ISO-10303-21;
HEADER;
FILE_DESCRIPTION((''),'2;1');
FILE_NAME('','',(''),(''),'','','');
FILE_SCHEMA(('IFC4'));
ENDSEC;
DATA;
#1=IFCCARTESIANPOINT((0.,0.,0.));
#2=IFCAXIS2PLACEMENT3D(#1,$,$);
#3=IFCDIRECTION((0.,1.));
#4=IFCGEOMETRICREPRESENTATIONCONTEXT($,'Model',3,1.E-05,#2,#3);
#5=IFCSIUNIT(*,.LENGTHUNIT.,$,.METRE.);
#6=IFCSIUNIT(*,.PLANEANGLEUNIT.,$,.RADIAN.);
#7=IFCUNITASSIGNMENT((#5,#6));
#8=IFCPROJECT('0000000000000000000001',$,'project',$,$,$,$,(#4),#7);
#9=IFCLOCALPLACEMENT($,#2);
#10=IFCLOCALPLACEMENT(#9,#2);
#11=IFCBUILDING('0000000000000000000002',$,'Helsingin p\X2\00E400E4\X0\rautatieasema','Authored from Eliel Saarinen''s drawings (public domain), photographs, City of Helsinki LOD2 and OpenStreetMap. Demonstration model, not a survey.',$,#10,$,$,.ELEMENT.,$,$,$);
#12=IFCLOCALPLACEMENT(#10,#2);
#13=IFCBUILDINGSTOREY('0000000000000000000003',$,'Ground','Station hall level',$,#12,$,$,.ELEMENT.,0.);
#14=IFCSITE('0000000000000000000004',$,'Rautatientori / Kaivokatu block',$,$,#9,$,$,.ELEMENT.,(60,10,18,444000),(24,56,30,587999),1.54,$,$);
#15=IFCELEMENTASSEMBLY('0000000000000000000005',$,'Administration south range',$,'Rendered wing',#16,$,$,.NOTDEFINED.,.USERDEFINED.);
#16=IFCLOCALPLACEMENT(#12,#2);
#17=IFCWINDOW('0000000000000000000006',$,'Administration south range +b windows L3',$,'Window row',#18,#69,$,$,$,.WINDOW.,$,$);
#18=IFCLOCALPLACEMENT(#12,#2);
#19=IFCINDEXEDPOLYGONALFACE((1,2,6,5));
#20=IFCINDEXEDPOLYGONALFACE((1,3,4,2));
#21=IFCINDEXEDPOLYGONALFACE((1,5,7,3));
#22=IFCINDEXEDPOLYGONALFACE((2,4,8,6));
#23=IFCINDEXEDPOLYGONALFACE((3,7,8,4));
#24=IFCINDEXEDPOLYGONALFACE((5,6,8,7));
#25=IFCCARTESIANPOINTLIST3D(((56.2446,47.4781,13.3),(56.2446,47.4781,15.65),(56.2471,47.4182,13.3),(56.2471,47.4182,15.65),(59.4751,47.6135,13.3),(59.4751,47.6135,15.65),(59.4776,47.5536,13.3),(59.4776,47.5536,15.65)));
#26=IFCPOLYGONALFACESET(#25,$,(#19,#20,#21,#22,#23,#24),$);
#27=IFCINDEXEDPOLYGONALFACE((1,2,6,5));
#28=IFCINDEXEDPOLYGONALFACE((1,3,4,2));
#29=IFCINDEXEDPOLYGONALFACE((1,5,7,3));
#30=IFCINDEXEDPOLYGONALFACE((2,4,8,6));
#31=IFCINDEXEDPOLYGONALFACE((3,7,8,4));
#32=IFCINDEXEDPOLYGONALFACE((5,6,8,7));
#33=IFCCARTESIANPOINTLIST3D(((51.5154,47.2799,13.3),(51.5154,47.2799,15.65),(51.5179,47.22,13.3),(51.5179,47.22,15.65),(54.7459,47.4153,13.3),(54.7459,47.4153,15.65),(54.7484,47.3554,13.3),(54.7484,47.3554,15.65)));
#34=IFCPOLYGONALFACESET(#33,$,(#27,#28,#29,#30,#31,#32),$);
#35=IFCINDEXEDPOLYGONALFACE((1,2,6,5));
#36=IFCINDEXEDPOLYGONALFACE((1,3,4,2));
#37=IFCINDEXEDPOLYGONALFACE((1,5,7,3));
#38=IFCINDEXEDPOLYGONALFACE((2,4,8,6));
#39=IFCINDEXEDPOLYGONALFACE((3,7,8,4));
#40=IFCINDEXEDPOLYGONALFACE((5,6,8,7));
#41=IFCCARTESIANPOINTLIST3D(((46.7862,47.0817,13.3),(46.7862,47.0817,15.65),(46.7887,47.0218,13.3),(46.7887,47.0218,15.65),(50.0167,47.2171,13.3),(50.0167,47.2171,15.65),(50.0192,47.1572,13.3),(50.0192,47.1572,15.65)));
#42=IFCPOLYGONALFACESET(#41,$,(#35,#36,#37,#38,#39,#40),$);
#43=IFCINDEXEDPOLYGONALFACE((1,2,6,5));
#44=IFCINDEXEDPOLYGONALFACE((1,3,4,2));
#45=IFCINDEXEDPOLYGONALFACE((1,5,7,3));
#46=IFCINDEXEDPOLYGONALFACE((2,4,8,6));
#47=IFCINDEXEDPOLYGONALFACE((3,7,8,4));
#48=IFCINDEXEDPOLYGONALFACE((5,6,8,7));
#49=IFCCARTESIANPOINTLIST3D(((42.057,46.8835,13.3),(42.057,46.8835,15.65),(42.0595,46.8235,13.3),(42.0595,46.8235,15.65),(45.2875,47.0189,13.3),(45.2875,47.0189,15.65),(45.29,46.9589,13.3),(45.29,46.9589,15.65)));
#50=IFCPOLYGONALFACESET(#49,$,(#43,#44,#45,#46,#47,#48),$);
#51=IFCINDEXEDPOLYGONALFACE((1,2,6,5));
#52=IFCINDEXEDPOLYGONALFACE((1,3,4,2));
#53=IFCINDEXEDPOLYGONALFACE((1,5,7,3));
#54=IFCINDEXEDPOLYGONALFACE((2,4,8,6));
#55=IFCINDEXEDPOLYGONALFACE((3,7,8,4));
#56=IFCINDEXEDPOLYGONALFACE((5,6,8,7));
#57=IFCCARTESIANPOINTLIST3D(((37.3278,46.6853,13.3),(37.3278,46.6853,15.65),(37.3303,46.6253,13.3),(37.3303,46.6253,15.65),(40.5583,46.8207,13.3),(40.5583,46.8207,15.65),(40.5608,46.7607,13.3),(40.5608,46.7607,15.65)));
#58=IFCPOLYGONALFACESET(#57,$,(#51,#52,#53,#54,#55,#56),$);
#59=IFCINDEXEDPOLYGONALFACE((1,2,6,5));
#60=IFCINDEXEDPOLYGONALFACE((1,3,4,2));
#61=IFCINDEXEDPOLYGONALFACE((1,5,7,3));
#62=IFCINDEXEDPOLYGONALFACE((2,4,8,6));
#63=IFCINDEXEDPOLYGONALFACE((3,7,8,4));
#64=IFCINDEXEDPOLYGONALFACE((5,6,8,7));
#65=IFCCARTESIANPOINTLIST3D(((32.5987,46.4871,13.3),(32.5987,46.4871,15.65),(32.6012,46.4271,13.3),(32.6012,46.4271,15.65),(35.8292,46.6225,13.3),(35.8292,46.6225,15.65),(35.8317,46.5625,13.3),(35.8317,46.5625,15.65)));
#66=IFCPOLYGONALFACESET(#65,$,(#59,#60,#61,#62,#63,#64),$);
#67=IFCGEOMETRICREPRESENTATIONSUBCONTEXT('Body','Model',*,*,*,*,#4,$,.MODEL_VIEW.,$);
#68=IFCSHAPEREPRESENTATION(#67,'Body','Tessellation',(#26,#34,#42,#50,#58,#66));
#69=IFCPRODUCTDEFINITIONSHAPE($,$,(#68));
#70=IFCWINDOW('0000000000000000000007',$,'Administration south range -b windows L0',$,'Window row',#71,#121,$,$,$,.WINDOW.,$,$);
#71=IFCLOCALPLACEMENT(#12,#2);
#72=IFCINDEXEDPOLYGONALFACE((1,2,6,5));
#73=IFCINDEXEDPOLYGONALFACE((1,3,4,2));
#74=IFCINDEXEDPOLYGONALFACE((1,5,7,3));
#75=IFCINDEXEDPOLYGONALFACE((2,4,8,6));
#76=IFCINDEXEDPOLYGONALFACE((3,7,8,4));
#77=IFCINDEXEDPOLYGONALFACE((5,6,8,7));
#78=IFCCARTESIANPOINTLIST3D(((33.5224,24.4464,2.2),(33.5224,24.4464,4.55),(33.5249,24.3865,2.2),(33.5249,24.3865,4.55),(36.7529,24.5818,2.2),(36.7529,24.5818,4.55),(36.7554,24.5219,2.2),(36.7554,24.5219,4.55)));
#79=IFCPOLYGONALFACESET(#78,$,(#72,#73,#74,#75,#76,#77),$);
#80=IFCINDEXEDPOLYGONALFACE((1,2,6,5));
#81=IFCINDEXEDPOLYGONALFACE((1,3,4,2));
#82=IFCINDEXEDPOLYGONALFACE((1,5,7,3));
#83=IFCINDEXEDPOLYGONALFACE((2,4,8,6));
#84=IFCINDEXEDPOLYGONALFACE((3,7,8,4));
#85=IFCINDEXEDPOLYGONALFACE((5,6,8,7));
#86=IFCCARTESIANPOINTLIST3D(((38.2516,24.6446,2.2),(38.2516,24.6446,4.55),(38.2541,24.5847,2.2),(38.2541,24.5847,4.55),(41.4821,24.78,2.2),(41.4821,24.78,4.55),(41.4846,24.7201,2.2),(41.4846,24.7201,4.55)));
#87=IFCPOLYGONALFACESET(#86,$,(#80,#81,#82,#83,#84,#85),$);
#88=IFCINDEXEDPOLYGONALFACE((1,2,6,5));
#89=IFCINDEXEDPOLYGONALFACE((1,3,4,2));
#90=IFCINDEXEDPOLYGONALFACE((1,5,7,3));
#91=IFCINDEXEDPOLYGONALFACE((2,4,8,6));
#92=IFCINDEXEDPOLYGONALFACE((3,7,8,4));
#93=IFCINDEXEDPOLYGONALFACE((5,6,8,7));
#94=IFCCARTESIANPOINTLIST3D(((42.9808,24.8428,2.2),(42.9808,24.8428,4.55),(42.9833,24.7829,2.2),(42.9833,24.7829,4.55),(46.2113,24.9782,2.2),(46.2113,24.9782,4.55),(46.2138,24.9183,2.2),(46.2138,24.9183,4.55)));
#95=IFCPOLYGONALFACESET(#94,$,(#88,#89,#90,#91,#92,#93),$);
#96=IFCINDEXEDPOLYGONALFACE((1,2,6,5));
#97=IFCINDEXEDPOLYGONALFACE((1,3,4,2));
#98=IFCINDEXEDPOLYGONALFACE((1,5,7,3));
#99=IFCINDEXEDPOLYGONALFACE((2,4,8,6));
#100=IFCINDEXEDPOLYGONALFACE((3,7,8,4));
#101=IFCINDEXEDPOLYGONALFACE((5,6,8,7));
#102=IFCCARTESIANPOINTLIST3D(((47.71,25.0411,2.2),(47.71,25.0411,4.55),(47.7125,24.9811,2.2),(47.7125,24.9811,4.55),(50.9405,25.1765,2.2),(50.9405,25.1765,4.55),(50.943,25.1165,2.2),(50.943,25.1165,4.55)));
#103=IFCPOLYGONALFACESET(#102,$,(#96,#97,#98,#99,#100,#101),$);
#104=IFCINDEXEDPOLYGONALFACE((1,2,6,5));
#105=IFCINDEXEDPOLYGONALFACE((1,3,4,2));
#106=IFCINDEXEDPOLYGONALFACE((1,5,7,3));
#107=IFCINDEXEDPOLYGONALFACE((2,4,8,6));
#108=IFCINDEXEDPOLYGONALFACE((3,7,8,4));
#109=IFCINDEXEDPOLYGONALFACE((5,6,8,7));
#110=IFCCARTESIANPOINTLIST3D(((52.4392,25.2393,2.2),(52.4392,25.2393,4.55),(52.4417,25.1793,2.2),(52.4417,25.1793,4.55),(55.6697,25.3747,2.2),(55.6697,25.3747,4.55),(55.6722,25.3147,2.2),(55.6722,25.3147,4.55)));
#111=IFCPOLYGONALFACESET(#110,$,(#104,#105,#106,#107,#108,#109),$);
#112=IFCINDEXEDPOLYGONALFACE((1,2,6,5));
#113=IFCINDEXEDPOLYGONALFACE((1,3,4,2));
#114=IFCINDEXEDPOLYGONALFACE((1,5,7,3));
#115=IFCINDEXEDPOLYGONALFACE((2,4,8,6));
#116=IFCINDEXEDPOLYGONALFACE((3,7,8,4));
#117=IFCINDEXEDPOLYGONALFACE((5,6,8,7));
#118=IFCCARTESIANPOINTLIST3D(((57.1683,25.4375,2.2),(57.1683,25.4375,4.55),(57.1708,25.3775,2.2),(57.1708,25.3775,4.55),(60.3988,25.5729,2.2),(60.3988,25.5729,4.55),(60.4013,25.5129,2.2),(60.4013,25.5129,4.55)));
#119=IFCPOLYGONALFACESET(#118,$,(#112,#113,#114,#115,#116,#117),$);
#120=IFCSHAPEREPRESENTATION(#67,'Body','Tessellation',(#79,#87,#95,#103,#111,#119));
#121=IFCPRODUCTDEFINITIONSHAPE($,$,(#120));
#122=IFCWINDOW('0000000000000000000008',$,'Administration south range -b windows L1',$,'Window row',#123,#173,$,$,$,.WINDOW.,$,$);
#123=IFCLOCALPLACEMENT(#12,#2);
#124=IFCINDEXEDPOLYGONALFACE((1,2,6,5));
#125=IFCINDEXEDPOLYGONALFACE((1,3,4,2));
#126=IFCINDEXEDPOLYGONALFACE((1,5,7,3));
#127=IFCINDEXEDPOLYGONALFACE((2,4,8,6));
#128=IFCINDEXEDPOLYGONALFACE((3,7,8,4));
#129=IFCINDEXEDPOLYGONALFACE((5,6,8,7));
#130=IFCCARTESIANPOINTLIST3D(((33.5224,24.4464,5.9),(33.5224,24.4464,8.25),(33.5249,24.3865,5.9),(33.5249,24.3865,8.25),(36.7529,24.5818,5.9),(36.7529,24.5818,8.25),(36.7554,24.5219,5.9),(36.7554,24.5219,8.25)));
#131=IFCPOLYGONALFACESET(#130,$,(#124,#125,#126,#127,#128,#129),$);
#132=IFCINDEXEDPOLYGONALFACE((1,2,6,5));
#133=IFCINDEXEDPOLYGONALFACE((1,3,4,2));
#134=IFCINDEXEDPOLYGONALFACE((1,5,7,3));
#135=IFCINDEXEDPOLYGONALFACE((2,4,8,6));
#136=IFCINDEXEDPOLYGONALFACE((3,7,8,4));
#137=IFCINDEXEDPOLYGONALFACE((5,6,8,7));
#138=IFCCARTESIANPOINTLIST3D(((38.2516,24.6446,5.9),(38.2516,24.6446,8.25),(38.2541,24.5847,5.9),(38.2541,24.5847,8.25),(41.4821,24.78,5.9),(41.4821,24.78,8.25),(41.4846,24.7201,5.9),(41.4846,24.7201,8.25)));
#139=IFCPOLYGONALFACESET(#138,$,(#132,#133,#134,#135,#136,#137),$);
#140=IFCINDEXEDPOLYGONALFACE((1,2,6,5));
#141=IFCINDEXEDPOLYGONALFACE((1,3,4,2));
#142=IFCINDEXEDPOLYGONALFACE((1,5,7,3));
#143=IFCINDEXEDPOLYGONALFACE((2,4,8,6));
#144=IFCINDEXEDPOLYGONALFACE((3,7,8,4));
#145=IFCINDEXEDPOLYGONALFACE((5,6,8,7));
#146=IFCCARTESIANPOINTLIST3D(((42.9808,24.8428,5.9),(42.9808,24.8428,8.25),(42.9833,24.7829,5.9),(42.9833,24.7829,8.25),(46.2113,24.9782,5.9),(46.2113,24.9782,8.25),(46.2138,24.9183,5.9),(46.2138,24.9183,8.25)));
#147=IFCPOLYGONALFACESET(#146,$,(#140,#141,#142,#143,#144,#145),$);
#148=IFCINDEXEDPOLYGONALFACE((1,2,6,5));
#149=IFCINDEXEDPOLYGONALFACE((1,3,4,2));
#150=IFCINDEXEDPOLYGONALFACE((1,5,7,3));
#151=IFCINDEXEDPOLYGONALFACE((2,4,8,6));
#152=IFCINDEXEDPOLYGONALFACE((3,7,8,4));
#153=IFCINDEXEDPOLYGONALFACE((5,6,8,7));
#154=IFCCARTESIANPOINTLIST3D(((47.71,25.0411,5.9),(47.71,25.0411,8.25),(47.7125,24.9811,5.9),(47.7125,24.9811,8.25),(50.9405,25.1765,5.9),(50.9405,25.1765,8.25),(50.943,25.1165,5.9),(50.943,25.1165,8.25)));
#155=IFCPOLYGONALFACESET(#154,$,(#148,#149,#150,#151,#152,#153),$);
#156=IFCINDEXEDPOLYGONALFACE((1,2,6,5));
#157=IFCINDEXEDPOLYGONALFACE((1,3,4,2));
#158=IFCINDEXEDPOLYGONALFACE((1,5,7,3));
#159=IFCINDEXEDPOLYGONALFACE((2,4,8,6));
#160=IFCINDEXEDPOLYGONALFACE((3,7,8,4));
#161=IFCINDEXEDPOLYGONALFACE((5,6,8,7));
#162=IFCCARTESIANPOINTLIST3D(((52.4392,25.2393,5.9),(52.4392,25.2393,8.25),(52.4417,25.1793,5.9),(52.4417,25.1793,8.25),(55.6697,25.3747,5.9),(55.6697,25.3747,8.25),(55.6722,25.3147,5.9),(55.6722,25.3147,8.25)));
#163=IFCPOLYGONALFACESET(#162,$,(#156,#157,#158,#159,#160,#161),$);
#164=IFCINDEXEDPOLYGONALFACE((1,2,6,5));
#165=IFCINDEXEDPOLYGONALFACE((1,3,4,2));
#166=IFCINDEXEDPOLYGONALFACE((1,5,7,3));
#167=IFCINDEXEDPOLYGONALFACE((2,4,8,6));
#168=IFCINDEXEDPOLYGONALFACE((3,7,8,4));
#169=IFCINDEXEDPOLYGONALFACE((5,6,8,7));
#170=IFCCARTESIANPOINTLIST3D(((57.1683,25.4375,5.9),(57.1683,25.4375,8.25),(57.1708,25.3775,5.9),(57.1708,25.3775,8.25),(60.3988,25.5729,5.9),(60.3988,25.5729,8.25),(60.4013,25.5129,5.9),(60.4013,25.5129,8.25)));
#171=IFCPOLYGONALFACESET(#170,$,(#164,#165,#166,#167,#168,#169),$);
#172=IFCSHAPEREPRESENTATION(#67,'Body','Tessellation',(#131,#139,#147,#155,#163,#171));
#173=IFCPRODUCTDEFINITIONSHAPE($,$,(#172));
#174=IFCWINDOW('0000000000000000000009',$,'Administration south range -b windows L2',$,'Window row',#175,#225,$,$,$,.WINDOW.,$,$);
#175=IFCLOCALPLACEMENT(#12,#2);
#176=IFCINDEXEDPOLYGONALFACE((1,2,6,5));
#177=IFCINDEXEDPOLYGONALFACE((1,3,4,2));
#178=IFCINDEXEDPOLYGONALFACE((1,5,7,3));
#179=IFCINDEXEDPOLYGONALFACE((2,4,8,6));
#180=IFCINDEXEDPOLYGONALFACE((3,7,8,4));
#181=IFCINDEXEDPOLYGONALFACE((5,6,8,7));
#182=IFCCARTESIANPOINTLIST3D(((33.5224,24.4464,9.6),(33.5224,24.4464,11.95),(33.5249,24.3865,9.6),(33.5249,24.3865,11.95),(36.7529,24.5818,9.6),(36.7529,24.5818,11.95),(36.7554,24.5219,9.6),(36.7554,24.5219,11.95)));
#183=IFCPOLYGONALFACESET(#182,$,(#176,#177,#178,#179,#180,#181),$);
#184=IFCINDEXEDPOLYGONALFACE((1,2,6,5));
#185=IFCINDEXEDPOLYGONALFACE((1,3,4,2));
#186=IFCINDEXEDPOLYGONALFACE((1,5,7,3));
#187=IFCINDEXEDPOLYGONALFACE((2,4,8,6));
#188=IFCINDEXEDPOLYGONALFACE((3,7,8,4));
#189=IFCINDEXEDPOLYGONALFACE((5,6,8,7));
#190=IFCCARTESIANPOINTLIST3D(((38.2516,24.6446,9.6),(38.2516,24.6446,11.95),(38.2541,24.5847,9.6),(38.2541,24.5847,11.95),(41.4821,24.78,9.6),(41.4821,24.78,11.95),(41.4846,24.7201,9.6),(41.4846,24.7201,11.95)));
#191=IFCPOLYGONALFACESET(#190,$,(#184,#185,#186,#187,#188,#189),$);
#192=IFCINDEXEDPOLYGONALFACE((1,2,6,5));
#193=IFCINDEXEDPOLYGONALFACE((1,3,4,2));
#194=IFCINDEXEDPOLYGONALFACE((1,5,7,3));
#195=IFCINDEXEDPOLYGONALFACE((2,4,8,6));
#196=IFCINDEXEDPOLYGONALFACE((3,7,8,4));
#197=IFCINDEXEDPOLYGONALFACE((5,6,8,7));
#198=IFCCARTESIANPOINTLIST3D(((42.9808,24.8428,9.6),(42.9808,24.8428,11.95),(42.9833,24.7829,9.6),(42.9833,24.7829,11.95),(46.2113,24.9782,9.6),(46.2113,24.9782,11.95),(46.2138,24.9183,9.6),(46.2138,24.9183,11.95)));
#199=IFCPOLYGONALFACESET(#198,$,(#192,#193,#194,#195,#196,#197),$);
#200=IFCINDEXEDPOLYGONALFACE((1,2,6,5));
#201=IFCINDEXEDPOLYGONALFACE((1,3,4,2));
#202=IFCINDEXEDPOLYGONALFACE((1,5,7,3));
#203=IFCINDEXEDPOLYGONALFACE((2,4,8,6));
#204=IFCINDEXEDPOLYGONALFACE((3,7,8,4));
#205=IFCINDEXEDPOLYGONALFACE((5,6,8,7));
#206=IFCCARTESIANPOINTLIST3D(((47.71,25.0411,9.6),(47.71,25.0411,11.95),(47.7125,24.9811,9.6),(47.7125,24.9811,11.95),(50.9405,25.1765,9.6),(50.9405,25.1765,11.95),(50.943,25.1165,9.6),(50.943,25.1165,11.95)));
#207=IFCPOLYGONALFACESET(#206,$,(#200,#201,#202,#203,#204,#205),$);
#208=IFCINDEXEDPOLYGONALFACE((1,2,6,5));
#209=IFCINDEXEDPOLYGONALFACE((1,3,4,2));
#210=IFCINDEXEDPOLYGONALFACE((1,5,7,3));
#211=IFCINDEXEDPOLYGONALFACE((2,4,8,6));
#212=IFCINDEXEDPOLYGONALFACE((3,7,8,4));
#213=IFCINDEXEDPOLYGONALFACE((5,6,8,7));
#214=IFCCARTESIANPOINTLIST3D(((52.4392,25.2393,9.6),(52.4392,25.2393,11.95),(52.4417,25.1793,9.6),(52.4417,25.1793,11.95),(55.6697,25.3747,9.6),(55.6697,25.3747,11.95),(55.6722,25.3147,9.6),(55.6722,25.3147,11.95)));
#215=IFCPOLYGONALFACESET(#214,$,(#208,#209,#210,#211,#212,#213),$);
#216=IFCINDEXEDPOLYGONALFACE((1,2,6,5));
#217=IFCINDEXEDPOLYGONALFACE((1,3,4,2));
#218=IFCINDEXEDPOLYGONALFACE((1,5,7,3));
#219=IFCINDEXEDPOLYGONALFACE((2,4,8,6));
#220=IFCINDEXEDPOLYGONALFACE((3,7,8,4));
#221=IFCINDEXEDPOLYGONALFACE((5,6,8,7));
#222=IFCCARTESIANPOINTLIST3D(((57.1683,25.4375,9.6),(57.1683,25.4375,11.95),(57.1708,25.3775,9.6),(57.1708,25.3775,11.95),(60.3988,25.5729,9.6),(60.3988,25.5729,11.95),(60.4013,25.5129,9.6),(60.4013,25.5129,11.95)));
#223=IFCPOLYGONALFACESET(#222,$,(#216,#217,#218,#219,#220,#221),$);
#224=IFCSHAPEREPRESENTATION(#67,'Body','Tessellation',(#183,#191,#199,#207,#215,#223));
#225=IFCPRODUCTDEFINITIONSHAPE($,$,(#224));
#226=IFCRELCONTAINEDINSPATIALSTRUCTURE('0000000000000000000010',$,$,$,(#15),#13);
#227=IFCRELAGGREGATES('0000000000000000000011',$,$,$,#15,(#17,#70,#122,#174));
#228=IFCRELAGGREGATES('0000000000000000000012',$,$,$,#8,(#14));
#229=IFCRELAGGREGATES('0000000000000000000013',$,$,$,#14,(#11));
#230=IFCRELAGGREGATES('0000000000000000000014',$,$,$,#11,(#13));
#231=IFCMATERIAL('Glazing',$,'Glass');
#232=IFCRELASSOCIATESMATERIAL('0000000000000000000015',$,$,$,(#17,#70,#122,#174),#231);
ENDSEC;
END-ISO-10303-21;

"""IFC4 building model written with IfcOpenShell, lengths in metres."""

from ifc_helpers import new_model, si_unit, direction, frame, frame_2d, origin, place, context, subcontext, project, spatial, rectangle, extrude, material, element, aggregate, save


model = new_model("IFC4")

# Units and contexts
model_context = context("Model", 3, precision=1e-05, world=origin(), true_north=direction((0.0, 1.0)))
body_context = subcontext(model_context, "Body", "Model", "MODEL_VIEW")
ifc_project = project(units=[si_unit("LENGTHUNIT", "METRE"), si_unit("PLANEANGLEUNIT", "RADIAN")], contexts=[model_context])

# Site, building, storey
site_placement = place(None, origin())
site = spatial("IfcSite", under=ifc_project, at=site_placement, Name="Rautatientori / Kaivokatu block", CompositionType="ELEMENT", RefLatitude=(60, 10, 18, 444000), RefLongitude=(24, 56, 30, 587999), RefElevation=1.54)
building_placement = place(site_placement, origin())
building = spatial("IfcBuilding", under=site, at=building_placement, Name="Helsingin päärautatieasema", Description="Authored from Eliel Saarinen's drawings (public domain), photographs, City of Helsinki LOD2 and OpenStreetMap. Demonstration model, not a survey.", CompositionType="ELEMENT")
storey_placement = place(building_placement, origin())
storey = spatial("IfcBuildingStorey", under=building, at=storey_placement, Name="Ground", Description="Station hall level", CompositionType="ELEMENT", Elevation=0.0)

# Element assembly
assembly_1_placement = place(building_placement, origin())
assembly_1 = element("IfcElementAssembly", 1, at=assembly_1_placement, inside=storey, Name="Administration south range", ObjectType="Rendered wing", AssemblyPlace="NOTDEFINED", PredefinedType="USERDEFINED")

# Windows
ifc_material_1 = material(Name="Glazing", Category="Glass")
window_1_placement = place(building_placement, origin())
window_1 = element("IfcWindow", 2, at=window_1_placement, material=ifc_material_1, Name="Administration south range +b windows L3", ObjectType="Window row", PredefinedType="WINDOW", context=body_context, shape_type="SweptSolid", body=[
    extrude(rectangle(XDim=3.2333, YDim=0.06, at=frame_2d((0.0, 0.0), x_axis=(-0.999123, -0.041876))), frame((57.8611, 47.5159, 13.3)), (0.0, 0.0, 1.0), 2.35),
    extrude(rectangle(XDim=3.2333, YDim=0.06, at=frame_2d((0.0, 0.0), x_axis=(-0.999123, -0.041876))), frame((53.1319, 47.3176, 13.3)), (0.0, 0.0, 1.0), 2.35),
    extrude(rectangle(XDim=3.2333, YDim=0.06, at=frame_2d((0.0, 0.0), x_axis=(-0.999123, -0.041876))), frame((48.4027, 47.1194, 13.3)), (0.0, 0.0, 1.0), 2.35),
    extrude(rectangle(XDim=3.2333, YDim=0.06, at=frame_2d((0.0, 0.0), x_axis=(-0.999123, -0.041876))), frame((43.6735, 46.9212, 13.3)), (0.0, 0.0, 1.0), 2.35),
    extrude(rectangle(XDim=3.2333, YDim=0.06, at=frame_2d((0.0, 0.0), x_axis=(-0.999123, -0.041876))), frame((38.9443, 46.723, 13.3)), (0.0, 0.0, 1.0), 2.35),
    extrude(rectangle(XDim=3.2333, YDim=0.06, at=frame_2d((0.0, 0.0), x_axis=(-0.999123, -0.041876))), frame((34.2152, 46.5248, 13.3)), (0.0, 0.0, 1.0), 2.35),
])
window_2_placement = place(building_placement, origin())
window_2 = element("IfcWindow", 3, at=window_2_placement, material=ifc_material_1, Name="Administration south range -b windows L0", ObjectType="Window row", PredefinedType="WINDOW", context=body_context, shape_type="SweptSolid", body=[
    extrude(rectangle(XDim=3.2333, YDim=0.06, at=frame_2d((0.0, 0.0), x_axis=(0.999123, 0.041876))), frame((35.1389, 24.4841, 2.2)), (0.0, 0.0, 1.0), 2.35),
    extrude(rectangle(XDim=3.2333, YDim=0.06, at=frame_2d((0.0, 0.0), x_axis=(0.999123, 0.041876))), frame((39.8681, 24.6824, 2.2)), (0.0, 0.0, 1.0), 2.35),
    extrude(rectangle(XDim=3.2333, YDim=0.06, at=frame_2d((0.0, 0.0), x_axis=(0.999123, 0.041876))), frame((44.5973, 24.8806, 2.2)), (0.0, 0.0, 1.0), 2.35),
    extrude(rectangle(XDim=3.2333, YDim=0.06, at=frame_2d((0.0, 0.0), x_axis=(0.999123, 0.041876))), frame((49.3265, 25.0788, 2.2)), (0.0, 0.0, 1.0), 2.35),
    extrude(rectangle(XDim=3.2333, YDim=0.06, at=frame_2d((0.0, 0.0), x_axis=(0.999123, 0.041876))), frame((54.0557, 25.277, 2.2)), (0.0, 0.0, 1.0), 2.35),
    extrude(rectangle(XDim=3.2333, YDim=0.06, at=frame_2d((0.0, 0.0), x_axis=(0.999123, 0.041876))), frame((58.7848, 25.4752, 2.2)), (0.0, 0.0, 1.0), 2.35),
])
window_3_placement = place(building_placement, origin())
window_3 = element("IfcWindow", 4, at=window_3_placement, material=ifc_material_1, Name="Administration south range -b windows L1", ObjectType="Window row", PredefinedType="WINDOW", context=body_context, shape_type="SweptSolid", body=[
    extrude(rectangle(XDim=3.2333, YDim=0.06, at=frame_2d((0.0, 0.0), x_axis=(0.999123, 0.041876))), frame((35.1389, 24.4841, 5.9)), (0.0, 0.0, 1.0), 2.35),
    extrude(rectangle(XDim=3.2333, YDim=0.06, at=frame_2d((0.0, 0.0), x_axis=(0.999123, 0.041876))), frame((39.8681, 24.6824, 5.9)), (0.0, 0.0, 1.0), 2.35),
    extrude(rectangle(XDim=3.2333, YDim=0.06, at=frame_2d((0.0, 0.0), x_axis=(0.999123, 0.041876))), frame((44.5973, 24.8806, 5.9)), (0.0, 0.0, 1.0), 2.35),
    extrude(rectangle(XDim=3.2333, YDim=0.06, at=frame_2d((0.0, 0.0), x_axis=(0.999123, 0.041876))), frame((49.3265, 25.0788, 5.9)), (0.0, 0.0, 1.0), 2.35),
    extrude(rectangle(XDim=3.2333, YDim=0.06, at=frame_2d((0.0, 0.0), x_axis=(0.999123, 0.041876))), frame((54.0557, 25.277, 5.9)), (0.0, 0.0, 1.0), 2.35),
    extrude(rectangle(XDim=3.2333, YDim=0.06, at=frame_2d((0.0, 0.0), x_axis=(0.999123, 0.041876))), frame((58.7848, 25.4752, 5.9)), (0.0, 0.0, 1.0), 2.35),
])
window_4_placement = place(building_placement, origin())
window_4 = element("IfcWindow", 5, at=window_4_placement, material=ifc_material_1, Name="Administration south range -b windows L2", ObjectType="Window row", PredefinedType="WINDOW", context=body_context, shape_type="SweptSolid", body=[
    extrude(rectangle(XDim=3.2333, YDim=0.06, at=frame_2d((0.0, 0.0), x_axis=(0.999123, 0.041876))), frame((35.1389, 24.4841, 9.6)), (0.0, 0.0, 1.0), 2.35),
    extrude(rectangle(XDim=3.2333, YDim=0.06, at=frame_2d((0.0, 0.0), x_axis=(0.999123, 0.041876))), frame((39.8681, 24.6824, 9.6)), (0.0, 0.0, 1.0), 2.35),
    extrude(rectangle(XDim=3.2333, YDim=0.06, at=frame_2d((0.0, 0.0), x_axis=(0.999123, 0.041876))), frame((44.5973, 24.8806, 9.6)), (0.0, 0.0, 1.0), 2.35),
    extrude(rectangle(XDim=3.2333, YDim=0.06, at=frame_2d((0.0, 0.0), x_axis=(0.999123, 0.041876))), frame((49.3265, 25.0788, 9.6)), (0.0, 0.0, 1.0), 2.35),
    extrude(rectangle(XDim=3.2333, YDim=0.06, at=frame_2d((0.0, 0.0), x_axis=(0.999123, 0.041876))), frame((54.0557, 25.277, 9.6)), (0.0, 0.0, 1.0), 2.35),
    extrude(rectangle(XDim=3.2333, YDim=0.06, at=frame_2d((0.0, 0.0), x_axis=(0.999123, 0.041876))), frame((58.7848, 25.4752, 9.6)), (0.0, 0.0, 1.0), 2.35),
])

aggregate(assembly_1, [window_1, window_2, window_3, window_4])

save(model, "model.ifc")
